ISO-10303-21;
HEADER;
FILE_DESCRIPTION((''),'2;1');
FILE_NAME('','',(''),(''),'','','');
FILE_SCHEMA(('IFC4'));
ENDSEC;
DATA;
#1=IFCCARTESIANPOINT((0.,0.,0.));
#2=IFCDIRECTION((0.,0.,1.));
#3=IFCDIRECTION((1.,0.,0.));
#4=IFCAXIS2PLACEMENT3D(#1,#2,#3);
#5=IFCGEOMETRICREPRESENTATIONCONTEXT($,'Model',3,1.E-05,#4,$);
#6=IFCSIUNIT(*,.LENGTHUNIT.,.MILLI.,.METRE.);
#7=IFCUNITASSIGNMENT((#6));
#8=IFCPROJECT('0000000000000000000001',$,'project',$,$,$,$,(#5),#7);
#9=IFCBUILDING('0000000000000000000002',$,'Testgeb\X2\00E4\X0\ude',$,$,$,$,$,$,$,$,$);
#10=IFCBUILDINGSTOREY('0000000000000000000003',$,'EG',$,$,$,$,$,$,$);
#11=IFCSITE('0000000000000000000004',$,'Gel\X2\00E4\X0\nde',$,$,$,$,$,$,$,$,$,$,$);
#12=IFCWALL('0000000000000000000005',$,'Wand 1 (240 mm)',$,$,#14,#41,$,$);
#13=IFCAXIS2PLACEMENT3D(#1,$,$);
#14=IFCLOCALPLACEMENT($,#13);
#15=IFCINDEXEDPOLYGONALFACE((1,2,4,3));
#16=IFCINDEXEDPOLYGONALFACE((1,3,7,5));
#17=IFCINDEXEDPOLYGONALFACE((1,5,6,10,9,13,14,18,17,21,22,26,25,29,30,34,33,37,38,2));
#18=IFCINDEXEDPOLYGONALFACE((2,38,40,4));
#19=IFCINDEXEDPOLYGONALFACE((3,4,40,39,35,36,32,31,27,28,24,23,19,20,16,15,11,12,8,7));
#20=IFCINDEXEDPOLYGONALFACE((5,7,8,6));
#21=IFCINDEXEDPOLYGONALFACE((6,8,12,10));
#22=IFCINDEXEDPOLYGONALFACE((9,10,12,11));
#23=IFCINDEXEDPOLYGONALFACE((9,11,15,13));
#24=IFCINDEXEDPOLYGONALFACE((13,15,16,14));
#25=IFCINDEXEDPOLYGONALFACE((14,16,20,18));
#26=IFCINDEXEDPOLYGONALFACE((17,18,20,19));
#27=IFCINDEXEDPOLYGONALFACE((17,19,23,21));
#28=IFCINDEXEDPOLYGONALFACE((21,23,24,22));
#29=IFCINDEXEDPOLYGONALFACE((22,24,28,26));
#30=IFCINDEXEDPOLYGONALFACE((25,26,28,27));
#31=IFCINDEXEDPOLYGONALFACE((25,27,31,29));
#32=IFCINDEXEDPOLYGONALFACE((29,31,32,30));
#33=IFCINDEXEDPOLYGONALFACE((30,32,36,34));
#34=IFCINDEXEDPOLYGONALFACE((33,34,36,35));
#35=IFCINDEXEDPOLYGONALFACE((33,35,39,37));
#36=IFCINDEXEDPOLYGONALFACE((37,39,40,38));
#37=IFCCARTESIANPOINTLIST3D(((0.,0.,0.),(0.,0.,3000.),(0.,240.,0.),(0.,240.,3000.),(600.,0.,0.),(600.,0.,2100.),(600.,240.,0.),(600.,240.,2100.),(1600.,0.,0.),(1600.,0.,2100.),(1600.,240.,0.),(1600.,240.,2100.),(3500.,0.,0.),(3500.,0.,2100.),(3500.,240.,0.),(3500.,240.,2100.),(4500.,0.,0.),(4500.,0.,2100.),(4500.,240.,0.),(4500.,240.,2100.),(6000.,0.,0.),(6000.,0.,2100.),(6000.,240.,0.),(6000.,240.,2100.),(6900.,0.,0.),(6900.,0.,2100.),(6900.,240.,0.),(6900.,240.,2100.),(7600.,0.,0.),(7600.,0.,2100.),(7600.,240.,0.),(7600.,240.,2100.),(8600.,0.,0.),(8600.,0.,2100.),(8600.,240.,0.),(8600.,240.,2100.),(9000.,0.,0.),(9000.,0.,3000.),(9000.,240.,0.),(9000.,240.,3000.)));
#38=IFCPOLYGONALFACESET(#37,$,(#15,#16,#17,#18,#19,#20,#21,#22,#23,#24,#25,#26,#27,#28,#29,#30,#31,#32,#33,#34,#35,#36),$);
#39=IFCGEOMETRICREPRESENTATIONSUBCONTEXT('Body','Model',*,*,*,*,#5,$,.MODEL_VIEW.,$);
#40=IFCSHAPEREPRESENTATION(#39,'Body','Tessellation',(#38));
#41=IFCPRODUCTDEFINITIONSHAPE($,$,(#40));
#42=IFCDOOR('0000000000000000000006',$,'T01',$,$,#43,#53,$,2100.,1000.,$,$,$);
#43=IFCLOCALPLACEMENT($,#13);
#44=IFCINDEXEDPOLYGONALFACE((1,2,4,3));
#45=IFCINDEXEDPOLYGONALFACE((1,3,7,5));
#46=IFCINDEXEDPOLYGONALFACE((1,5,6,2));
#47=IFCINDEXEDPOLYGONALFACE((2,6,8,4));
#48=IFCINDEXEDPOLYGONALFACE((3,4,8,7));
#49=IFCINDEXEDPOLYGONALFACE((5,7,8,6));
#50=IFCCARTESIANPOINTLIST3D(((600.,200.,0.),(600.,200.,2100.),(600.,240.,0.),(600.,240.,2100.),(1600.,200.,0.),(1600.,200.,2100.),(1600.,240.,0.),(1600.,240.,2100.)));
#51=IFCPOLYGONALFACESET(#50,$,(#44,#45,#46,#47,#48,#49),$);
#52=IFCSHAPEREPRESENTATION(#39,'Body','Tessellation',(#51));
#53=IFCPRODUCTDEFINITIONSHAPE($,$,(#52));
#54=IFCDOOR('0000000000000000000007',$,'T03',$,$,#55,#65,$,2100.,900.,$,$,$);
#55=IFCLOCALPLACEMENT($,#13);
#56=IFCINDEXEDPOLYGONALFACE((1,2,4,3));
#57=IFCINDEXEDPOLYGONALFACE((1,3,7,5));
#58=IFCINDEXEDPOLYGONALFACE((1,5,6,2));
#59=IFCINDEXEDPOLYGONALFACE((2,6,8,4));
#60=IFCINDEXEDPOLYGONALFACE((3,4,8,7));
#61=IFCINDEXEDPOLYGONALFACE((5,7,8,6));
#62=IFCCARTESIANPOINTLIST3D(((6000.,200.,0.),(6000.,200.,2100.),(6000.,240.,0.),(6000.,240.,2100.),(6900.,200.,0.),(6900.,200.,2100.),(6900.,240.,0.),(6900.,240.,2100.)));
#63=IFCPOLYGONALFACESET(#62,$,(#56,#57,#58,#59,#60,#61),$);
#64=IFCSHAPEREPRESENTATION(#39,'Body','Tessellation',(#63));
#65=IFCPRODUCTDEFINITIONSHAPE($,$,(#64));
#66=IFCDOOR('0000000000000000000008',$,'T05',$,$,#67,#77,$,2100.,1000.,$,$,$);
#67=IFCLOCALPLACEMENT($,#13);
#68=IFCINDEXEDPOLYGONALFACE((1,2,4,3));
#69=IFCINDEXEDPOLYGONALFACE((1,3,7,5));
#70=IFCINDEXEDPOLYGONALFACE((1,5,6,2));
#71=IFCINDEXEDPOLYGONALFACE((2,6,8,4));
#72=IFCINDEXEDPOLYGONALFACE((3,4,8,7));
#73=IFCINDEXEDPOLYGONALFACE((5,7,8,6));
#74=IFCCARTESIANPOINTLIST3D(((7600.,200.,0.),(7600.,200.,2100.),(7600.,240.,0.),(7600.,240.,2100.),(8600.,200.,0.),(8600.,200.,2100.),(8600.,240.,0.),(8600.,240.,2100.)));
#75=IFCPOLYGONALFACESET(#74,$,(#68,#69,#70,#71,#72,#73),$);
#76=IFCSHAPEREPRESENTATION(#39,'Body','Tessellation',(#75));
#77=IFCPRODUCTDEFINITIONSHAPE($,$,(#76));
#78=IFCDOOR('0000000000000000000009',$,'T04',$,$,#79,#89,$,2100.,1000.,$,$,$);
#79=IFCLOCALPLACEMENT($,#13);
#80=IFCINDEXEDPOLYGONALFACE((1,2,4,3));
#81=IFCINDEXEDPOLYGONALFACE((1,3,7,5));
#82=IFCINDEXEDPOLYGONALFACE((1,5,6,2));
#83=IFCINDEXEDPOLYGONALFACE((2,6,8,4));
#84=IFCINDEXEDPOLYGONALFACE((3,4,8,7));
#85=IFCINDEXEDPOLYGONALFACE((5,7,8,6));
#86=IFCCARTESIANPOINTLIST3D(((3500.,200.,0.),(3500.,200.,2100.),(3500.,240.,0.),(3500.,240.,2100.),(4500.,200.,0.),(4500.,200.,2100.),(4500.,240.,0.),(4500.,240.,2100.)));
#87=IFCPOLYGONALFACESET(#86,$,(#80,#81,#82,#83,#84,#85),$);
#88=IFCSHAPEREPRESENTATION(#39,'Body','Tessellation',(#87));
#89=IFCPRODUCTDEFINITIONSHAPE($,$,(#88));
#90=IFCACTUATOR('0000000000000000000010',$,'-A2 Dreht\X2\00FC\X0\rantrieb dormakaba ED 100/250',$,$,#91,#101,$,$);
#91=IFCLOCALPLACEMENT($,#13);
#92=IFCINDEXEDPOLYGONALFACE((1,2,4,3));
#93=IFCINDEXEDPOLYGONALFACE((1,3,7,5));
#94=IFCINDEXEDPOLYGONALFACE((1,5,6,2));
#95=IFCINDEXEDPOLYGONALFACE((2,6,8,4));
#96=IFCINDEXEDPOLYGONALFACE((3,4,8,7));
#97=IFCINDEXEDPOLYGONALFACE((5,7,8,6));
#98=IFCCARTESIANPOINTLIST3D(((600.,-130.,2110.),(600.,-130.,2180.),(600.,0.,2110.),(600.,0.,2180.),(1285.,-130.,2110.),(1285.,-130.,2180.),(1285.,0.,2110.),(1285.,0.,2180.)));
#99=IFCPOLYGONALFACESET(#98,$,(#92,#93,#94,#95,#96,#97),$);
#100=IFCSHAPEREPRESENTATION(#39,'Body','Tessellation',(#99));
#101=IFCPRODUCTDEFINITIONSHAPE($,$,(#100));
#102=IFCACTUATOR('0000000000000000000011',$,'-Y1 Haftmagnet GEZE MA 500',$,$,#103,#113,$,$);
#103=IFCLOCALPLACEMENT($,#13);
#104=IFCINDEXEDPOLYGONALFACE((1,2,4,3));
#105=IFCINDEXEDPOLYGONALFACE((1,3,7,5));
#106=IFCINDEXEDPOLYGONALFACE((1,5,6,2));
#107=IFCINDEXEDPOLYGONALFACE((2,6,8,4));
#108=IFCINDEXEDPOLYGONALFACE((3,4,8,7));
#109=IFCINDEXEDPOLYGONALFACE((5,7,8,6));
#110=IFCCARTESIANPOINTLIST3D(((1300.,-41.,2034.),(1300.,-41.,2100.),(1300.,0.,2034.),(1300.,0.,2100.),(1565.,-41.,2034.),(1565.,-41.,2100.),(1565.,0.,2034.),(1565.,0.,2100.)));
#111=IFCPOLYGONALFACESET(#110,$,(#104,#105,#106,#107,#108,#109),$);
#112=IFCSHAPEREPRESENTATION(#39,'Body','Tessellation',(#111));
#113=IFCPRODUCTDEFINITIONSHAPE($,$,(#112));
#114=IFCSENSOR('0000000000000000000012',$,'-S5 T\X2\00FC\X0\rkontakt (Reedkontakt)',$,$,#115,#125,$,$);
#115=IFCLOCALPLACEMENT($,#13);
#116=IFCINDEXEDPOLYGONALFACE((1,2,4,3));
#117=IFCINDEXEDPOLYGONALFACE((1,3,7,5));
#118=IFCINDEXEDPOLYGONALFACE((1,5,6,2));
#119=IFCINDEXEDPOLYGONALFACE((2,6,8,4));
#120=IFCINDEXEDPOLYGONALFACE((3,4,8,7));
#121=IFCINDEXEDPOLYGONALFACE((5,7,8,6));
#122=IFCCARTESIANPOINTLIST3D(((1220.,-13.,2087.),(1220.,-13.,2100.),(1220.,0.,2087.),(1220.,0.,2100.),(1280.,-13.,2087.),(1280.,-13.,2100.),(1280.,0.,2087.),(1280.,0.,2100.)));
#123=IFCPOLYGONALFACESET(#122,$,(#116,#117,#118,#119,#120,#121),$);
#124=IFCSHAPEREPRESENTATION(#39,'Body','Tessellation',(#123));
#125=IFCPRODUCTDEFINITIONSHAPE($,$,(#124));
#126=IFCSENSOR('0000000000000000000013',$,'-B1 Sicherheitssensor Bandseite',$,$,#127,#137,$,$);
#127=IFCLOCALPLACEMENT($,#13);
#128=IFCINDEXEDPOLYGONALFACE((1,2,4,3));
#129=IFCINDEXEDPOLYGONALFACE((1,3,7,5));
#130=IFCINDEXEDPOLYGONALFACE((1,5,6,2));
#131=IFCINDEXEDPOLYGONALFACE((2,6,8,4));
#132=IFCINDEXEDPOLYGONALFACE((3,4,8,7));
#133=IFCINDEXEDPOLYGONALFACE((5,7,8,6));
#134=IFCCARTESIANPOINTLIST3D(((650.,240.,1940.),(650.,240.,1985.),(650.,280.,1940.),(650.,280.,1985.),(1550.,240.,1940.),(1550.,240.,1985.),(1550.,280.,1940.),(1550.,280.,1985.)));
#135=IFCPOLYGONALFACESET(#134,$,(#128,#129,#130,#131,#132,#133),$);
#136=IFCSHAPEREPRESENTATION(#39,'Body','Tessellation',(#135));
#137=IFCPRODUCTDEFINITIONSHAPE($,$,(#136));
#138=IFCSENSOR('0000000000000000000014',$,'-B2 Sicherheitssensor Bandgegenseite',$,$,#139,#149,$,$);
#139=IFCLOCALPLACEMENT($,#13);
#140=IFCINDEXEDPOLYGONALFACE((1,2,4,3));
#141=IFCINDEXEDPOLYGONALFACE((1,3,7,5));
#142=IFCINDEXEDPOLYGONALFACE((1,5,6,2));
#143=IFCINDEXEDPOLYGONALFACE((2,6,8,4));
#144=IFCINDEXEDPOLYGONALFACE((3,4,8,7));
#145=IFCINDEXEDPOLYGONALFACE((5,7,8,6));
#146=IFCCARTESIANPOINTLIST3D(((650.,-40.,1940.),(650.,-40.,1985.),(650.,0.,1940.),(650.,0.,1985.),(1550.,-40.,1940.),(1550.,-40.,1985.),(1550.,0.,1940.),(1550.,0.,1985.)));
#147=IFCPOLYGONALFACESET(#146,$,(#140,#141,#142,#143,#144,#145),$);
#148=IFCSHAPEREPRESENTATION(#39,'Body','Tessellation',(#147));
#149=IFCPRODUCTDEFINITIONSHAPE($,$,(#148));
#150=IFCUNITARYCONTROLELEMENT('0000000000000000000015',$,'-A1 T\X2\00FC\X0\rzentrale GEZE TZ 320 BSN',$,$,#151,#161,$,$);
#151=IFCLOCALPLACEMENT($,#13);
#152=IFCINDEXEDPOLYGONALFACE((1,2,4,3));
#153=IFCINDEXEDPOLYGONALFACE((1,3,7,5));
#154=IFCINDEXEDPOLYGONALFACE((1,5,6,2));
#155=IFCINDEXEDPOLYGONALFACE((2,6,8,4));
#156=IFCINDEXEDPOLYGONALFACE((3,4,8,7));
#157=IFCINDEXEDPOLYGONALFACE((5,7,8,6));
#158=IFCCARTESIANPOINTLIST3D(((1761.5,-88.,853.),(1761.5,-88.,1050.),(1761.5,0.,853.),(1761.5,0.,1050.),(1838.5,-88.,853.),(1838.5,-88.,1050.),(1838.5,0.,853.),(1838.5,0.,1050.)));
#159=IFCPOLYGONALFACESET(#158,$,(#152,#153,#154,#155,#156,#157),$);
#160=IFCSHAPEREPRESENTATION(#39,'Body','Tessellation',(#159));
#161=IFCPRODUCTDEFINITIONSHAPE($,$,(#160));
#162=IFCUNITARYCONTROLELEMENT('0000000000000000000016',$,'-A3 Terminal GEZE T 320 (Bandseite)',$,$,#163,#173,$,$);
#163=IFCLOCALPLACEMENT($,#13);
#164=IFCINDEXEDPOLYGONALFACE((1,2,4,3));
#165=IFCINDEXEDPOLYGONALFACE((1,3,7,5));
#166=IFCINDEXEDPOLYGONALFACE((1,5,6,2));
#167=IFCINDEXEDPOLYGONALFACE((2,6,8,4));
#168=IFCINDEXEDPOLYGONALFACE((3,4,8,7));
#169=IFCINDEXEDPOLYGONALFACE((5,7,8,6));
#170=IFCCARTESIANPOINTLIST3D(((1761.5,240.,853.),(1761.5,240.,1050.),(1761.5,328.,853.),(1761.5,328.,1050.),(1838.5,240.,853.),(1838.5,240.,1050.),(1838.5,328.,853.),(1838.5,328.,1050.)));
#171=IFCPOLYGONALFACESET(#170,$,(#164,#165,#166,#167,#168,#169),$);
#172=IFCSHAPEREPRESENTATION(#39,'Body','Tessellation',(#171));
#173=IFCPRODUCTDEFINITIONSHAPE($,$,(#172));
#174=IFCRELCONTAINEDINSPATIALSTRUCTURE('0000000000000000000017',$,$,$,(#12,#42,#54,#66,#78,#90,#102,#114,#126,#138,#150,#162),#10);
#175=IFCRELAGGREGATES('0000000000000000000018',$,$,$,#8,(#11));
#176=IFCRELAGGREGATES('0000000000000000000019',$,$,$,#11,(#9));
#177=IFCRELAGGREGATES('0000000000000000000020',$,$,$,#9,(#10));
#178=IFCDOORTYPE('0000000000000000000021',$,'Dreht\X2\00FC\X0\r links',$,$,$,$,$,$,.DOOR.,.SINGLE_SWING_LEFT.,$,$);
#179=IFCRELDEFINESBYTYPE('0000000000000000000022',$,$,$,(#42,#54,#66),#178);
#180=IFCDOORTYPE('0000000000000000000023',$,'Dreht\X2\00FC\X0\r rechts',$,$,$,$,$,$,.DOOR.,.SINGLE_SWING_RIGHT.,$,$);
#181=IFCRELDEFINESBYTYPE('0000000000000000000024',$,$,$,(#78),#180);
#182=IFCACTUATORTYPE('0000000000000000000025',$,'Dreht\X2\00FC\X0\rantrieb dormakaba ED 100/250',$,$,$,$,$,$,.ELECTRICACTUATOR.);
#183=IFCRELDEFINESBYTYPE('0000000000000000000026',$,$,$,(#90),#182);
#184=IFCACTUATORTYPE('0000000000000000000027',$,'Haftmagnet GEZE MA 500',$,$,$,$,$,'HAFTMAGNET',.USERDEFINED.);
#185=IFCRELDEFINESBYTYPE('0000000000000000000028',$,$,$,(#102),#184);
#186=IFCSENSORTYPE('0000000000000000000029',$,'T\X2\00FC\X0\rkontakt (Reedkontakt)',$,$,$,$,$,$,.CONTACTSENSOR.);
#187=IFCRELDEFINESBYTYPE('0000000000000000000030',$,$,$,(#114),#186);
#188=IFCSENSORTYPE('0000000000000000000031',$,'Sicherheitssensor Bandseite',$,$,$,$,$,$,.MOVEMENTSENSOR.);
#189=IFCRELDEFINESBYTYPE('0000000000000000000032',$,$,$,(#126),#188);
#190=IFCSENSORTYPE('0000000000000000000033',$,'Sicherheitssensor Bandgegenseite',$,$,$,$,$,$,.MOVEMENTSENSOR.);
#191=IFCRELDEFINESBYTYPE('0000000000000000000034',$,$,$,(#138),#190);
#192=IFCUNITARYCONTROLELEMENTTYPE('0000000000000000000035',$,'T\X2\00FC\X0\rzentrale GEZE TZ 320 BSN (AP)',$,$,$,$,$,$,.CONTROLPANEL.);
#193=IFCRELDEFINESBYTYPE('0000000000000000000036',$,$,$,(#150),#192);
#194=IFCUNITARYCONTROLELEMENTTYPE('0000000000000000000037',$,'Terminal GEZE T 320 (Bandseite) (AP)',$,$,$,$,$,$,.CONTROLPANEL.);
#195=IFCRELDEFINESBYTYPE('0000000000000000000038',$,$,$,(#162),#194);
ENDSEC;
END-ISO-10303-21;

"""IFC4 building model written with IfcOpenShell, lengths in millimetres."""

from ifc_helpers import new_model, si_unit, frame, frame_2d, origin_with_axes, place, context, subcontext, project, spatial, rectangle, extrude, type_object, element, fill, save


model = new_model("IFC4")

# Units and contexts
model_context = context("Model", 3, precision=1e-05, world=origin_with_axes())
body_context = subcontext(model_context, "Body", "Model", "MODEL_VIEW")
ifc_project = project(units=[si_unit("LENGTHUNIT", "METRE", prefix="MILLI")], contexts=[model_context])

# Site, building, storey
site = spatial("IfcSite", under=ifc_project, Name="Gelände")
building = spatial("IfcBuilding", under=site, Name="Testgebäude")
storey = spatial("IfcBuildingStorey", under=building, Name="EG")

# Wall, openings, doors
wall_placement = place(None, origin_with_axes())
wall = element("IfcWall", 1, at=wall_placement, inside=storey, Name="Wand 1 (240 mm)", context=body_context, shape_type="SweptSolid", body=[
    extrude(rectangle(XDim=9000.0, YDim=240.0, at=frame_2d((4500.0, 120.0))), None, (0.0, 0.0, 1.0), 3000.0),
])
opening_1_placement = place(None, frame((600.0, 0.0, 0.0), z_axis=(0.0, 0.0, 1.0), x_axis=(1.0, 0.0, 0.0)))
opening_1 = element("IfcOpeningElement", 2, at=opening_1_placement, cuts=wall, context=body_context, shape_type="SweptSolid", body=[
    extrude(rectangle(XDim=1000.0, YDim=240.0, at=frame_2d((500.0, 120.0))), None, (0.0, 0.0, 1.0), 2100.0),
])
opening_2_placement = place(None, frame((3500.0, 0.0, 0.0), z_axis=(0.0, 0.0, 1.0), x_axis=(1.0, 0.0, 0.0)))
opening_2 = element("IfcOpeningElement", 3, at=opening_2_placement, cuts=wall, context=body_context, shape_type="SweptSolid", body=[
    extrude(rectangle(XDim=1000.0, YDim=240.0, at=frame_2d((500.0, 120.0))), None, (0.0, 0.0, 1.0), 2100.0),
])
opening_3_placement = place(None, frame((6000.0, 0.0, 0.0), z_axis=(0.0, 0.0, 1.0), x_axis=(1.0, 0.0, 0.0)))
opening_3 = element("IfcOpeningElement", 4, at=opening_3_placement, cuts=wall, context=body_context, shape_type="SweptSolid", body=[
    extrude(rectangle(XDim=900.0, YDim=240.0, at=frame_2d((450.0, 120.0))), None, (0.0, 0.0, 1.0), 2100.0),
])
opening_4_placement = place(None, frame((7600.0, 0.0, 0.0), z_axis=(0.0, 0.0, 1.0), x_axis=(1.0, 0.0, 0.0)))
opening_4 = element("IfcOpeningElement", 5, at=opening_4_placement, cuts=wall, context=body_context, shape_type="SweptSolid", body=[
    extrude(rectangle(XDim=1000.0, YDim=240.0, at=frame_2d((500.0, 120.0))), None, (0.0, 0.0, 1.0), 2100.0),
])
door_type_1 = type_object("IfcDoorType", Name="Drehtür links", OperationType="SINGLE_SWING_LEFT", PredefinedType="DOOR")
door_1_placement = place(opening_1_placement, origin_with_axes())
door_1 = element("IfcDoor", 6, at=door_1_placement, inside=storey, type_object=door_type_1, Name="T01", OverallHeight=2100.0, OverallWidth=1000.0, context=body_context, shape_type="SweptSolid", body=[
    extrude(rectangle(XDim=1000.0, YDim=40.0, at=frame_2d((500.0, 20.0))), frame((0.0, 200.0, 0.0)), (0.0, 0.0, 1.0), 2100.0),
])
fill(opening_1, door_1)
door_2_placement = place(opening_3_placement, origin_with_axes())
door_2 = element("IfcDoor", 7, at=door_2_placement, inside=storey, type_object=door_type_1, Name="T03", OverallHeight=2100.0, OverallWidth=900.0, context=body_context, shape_type="SweptSolid", body=[
    extrude(rectangle(XDim=900.0, YDim=40.0, at=frame_2d((450.0, 20.0))), frame((0.0, 200.0, 0.0)), (0.0, 0.0, 1.0), 2100.0),
])
fill(opening_3, door_2)
door_3_placement = place(opening_4_placement, origin_with_axes())
door_3 = element("IfcDoor", 8, at=door_3_placement, inside=storey, type_object=door_type_1, Name="T05", OverallHeight=2100.0, OverallWidth=1000.0, context=body_context, shape_type="SweptSolid", body=[
    extrude(rectangle(XDim=1000.0, YDim=40.0, at=frame_2d((500.0, 20.0))), frame((0.0, 200.0, 0.0)), (0.0, 0.0, 1.0), 2100.0),
])
fill(opening_4, door_3)
door_type_2 = type_object("IfcDoorType", Name="Drehtür rechts", OperationType="SINGLE_SWING_RIGHT", PredefinedType="DOOR")
door_4_placement = place(opening_2_placement, origin_with_axes())
door_4 = element("IfcDoor", 9, at=door_4_placement, inside=storey, type_object=door_type_2, Name="T04", OverallHeight=2100.0, OverallWidth=1000.0, context=body_context, shape_type="SweptSolid", body=[
    extrude(rectangle(XDim=1000.0, YDim=40.0, at=frame_2d((500.0, 20.0))), frame((0.0, 200.0, 0.0)), (0.0, 0.0, 1.0), 2100.0),
])
fill(opening_2, door_4)

# Actuators
actuator_type_1 = type_object("IfcActuatorType", Name="Drehtürantrieb dormakaba ED 100/250", PredefinedType="ELECTRICACTUATOR")
actuator_1_placement = place(None, frame((600.0, -130.0, 2110.0), z_axis=(0.0, 0.0, 1.0), x_axis=(1.0, 0.0, 0.0)))
element("IfcActuator", 10, at=actuator_1_placement, inside=storey, type_object=actuator_type_1, Name="-A2 Drehtürantrieb dormakaba ED 100/250", context=body_context, shape_type="SweptSolid", body=[
    extrude(rectangle(XDim=685.0, YDim=130.0, at=frame_2d((342.5, 65.0))), None, (0.0, 0.0, 1.0), 70.0),
])
actuator_type_2 = type_object("IfcActuatorType", Name="Haftmagnet GEZE MA 500", ElementType="HAFTMAGNET", PredefinedType="USERDEFINED")
actuator_2_placement = place(None, frame((1300.0, -41.0, 2034.0), z_axis=(0.0, 0.0, 1.0), x_axis=(1.0, 0.0, 0.0)))
element("IfcActuator", 11, at=actuator_2_placement, inside=storey, type_object=actuator_type_2, Name="-Y1 Haftmagnet GEZE MA 500", context=body_context, shape_type="SweptSolid", body=[
    extrude(rectangle(XDim=265.0, YDim=41.0, at=frame_2d((132.5, 20.5))), None, (0.0, 0.0, 1.0), 66.0),
])

# Sensors
sensor_type_1 = type_object("IfcSensorType", Name="Türkontakt (Reedkontakt)", PredefinedType="CONTACTSENSOR")
sensor_1_placement = place(None, frame((1220.0, -13.0, 2087.0), z_axis=(0.0, 0.0, 1.0), x_axis=(1.0, 0.0, 0.0)))
element("IfcSensor", 12, at=sensor_1_placement, inside=storey, type_object=sensor_type_1, Name="-S5 Türkontakt (Reedkontakt)", context=body_context, shape_type="SweptSolid", body=[
    extrude(rectangle(XDim=60.0, YDim=13.0, at=frame_2d((30.0, 6.5))), None, (0.0, 0.0, 1.0), 13.0),
])
sensor_type_2 = type_object("IfcSensorType", Name="Sicherheitssensor Bandseite", PredefinedType="MOVEMENTSENSOR")
sensor_2_placement = place(None, frame((650.0, 240.0, 1940.0), z_axis=(0.0, 0.0, 1.0), x_axis=(1.0, 0.0, 0.0)))
element("IfcSensor", 13, at=sensor_2_placement, inside=storey, type_object=sensor_type_2, Name="-B1 Sicherheitssensor Bandseite", context=body_context, shape_type="SweptSolid", body=[
    extrude(rectangle(XDim=900.0, YDim=40.0, at=frame_2d((450.0, 20.0))), None, (0.0, 0.0, 1.0), 45.0),
])
sensor_type_3 = type_object("IfcSensorType", Name="Sicherheitssensor Bandgegenseite", PredefinedType="MOVEMENTSENSOR")
sensor_3_placement = place(None, frame((650.0, -40.0, 1940.0), z_axis=(0.0, 0.0, 1.0), x_axis=(1.0, 0.0, 0.0)))
element("IfcSensor", 14, at=sensor_3_placement, inside=storey, type_object=sensor_type_3, Name="-B2 Sicherheitssensor Bandgegenseite", context=body_context, shape_type="SweptSolid", body=[
    extrude(rectangle(XDim=900.0, YDim=40.0, at=frame_2d((450.0, 20.0))), None, (0.0, 0.0, 1.0), 45.0),
])

# Unitary control elements
unitary_control_element_type_1 = type_object("IfcUnitaryControlElementType", Name="Türzentrale GEZE TZ 320 BSN (AP)", PredefinedType="CONTROLPANEL")
unitary_control_element_1_placement = place(None, frame((1761.5, -88.0, 853.0), z_axis=(0.0, 0.0, 1.0), x_axis=(1.0, 0.0, 0.0)))
element("IfcUnitaryControlElement", 15, at=unitary_control_element_1_placement, inside=storey, type_object=unitary_control_element_type_1, Name="-A1 Türzentrale GEZE TZ 320 BSN", context=body_context, shape_type="SweptSolid", body=[
    extrude(rectangle(XDim=77.0, YDim=88.0, at=frame_2d((38.5, 44.0))), None, (0.0, 0.0, 1.0), 197.0),
])
unitary_control_element_type_2 = type_object("IfcUnitaryControlElementType", Name="Terminal GEZE T 320 (Bandseite) (AP)", PredefinedType="CONTROLPANEL")
unitary_control_element_2_placement = place(None, frame((1761.5, 240.0, 853.0), z_axis=(0.0, 0.0, 1.0), x_axis=(1.0, 0.0, 0.0)))
element("IfcUnitaryControlElement", 16, at=unitary_control_element_2_placement, inside=storey, type_object=unitary_control_element_type_2, Name="-A3 Terminal GEZE T 320 (Bandseite)", context=body_context, shape_type="SweptSolid", body=[
    extrude(rectangle(XDim=77.0, YDim=88.0, at=frame_2d((38.5, 44.0))), None, (0.0, 0.0, 1.0), 197.0),
])

save(model, "model.ifc")
